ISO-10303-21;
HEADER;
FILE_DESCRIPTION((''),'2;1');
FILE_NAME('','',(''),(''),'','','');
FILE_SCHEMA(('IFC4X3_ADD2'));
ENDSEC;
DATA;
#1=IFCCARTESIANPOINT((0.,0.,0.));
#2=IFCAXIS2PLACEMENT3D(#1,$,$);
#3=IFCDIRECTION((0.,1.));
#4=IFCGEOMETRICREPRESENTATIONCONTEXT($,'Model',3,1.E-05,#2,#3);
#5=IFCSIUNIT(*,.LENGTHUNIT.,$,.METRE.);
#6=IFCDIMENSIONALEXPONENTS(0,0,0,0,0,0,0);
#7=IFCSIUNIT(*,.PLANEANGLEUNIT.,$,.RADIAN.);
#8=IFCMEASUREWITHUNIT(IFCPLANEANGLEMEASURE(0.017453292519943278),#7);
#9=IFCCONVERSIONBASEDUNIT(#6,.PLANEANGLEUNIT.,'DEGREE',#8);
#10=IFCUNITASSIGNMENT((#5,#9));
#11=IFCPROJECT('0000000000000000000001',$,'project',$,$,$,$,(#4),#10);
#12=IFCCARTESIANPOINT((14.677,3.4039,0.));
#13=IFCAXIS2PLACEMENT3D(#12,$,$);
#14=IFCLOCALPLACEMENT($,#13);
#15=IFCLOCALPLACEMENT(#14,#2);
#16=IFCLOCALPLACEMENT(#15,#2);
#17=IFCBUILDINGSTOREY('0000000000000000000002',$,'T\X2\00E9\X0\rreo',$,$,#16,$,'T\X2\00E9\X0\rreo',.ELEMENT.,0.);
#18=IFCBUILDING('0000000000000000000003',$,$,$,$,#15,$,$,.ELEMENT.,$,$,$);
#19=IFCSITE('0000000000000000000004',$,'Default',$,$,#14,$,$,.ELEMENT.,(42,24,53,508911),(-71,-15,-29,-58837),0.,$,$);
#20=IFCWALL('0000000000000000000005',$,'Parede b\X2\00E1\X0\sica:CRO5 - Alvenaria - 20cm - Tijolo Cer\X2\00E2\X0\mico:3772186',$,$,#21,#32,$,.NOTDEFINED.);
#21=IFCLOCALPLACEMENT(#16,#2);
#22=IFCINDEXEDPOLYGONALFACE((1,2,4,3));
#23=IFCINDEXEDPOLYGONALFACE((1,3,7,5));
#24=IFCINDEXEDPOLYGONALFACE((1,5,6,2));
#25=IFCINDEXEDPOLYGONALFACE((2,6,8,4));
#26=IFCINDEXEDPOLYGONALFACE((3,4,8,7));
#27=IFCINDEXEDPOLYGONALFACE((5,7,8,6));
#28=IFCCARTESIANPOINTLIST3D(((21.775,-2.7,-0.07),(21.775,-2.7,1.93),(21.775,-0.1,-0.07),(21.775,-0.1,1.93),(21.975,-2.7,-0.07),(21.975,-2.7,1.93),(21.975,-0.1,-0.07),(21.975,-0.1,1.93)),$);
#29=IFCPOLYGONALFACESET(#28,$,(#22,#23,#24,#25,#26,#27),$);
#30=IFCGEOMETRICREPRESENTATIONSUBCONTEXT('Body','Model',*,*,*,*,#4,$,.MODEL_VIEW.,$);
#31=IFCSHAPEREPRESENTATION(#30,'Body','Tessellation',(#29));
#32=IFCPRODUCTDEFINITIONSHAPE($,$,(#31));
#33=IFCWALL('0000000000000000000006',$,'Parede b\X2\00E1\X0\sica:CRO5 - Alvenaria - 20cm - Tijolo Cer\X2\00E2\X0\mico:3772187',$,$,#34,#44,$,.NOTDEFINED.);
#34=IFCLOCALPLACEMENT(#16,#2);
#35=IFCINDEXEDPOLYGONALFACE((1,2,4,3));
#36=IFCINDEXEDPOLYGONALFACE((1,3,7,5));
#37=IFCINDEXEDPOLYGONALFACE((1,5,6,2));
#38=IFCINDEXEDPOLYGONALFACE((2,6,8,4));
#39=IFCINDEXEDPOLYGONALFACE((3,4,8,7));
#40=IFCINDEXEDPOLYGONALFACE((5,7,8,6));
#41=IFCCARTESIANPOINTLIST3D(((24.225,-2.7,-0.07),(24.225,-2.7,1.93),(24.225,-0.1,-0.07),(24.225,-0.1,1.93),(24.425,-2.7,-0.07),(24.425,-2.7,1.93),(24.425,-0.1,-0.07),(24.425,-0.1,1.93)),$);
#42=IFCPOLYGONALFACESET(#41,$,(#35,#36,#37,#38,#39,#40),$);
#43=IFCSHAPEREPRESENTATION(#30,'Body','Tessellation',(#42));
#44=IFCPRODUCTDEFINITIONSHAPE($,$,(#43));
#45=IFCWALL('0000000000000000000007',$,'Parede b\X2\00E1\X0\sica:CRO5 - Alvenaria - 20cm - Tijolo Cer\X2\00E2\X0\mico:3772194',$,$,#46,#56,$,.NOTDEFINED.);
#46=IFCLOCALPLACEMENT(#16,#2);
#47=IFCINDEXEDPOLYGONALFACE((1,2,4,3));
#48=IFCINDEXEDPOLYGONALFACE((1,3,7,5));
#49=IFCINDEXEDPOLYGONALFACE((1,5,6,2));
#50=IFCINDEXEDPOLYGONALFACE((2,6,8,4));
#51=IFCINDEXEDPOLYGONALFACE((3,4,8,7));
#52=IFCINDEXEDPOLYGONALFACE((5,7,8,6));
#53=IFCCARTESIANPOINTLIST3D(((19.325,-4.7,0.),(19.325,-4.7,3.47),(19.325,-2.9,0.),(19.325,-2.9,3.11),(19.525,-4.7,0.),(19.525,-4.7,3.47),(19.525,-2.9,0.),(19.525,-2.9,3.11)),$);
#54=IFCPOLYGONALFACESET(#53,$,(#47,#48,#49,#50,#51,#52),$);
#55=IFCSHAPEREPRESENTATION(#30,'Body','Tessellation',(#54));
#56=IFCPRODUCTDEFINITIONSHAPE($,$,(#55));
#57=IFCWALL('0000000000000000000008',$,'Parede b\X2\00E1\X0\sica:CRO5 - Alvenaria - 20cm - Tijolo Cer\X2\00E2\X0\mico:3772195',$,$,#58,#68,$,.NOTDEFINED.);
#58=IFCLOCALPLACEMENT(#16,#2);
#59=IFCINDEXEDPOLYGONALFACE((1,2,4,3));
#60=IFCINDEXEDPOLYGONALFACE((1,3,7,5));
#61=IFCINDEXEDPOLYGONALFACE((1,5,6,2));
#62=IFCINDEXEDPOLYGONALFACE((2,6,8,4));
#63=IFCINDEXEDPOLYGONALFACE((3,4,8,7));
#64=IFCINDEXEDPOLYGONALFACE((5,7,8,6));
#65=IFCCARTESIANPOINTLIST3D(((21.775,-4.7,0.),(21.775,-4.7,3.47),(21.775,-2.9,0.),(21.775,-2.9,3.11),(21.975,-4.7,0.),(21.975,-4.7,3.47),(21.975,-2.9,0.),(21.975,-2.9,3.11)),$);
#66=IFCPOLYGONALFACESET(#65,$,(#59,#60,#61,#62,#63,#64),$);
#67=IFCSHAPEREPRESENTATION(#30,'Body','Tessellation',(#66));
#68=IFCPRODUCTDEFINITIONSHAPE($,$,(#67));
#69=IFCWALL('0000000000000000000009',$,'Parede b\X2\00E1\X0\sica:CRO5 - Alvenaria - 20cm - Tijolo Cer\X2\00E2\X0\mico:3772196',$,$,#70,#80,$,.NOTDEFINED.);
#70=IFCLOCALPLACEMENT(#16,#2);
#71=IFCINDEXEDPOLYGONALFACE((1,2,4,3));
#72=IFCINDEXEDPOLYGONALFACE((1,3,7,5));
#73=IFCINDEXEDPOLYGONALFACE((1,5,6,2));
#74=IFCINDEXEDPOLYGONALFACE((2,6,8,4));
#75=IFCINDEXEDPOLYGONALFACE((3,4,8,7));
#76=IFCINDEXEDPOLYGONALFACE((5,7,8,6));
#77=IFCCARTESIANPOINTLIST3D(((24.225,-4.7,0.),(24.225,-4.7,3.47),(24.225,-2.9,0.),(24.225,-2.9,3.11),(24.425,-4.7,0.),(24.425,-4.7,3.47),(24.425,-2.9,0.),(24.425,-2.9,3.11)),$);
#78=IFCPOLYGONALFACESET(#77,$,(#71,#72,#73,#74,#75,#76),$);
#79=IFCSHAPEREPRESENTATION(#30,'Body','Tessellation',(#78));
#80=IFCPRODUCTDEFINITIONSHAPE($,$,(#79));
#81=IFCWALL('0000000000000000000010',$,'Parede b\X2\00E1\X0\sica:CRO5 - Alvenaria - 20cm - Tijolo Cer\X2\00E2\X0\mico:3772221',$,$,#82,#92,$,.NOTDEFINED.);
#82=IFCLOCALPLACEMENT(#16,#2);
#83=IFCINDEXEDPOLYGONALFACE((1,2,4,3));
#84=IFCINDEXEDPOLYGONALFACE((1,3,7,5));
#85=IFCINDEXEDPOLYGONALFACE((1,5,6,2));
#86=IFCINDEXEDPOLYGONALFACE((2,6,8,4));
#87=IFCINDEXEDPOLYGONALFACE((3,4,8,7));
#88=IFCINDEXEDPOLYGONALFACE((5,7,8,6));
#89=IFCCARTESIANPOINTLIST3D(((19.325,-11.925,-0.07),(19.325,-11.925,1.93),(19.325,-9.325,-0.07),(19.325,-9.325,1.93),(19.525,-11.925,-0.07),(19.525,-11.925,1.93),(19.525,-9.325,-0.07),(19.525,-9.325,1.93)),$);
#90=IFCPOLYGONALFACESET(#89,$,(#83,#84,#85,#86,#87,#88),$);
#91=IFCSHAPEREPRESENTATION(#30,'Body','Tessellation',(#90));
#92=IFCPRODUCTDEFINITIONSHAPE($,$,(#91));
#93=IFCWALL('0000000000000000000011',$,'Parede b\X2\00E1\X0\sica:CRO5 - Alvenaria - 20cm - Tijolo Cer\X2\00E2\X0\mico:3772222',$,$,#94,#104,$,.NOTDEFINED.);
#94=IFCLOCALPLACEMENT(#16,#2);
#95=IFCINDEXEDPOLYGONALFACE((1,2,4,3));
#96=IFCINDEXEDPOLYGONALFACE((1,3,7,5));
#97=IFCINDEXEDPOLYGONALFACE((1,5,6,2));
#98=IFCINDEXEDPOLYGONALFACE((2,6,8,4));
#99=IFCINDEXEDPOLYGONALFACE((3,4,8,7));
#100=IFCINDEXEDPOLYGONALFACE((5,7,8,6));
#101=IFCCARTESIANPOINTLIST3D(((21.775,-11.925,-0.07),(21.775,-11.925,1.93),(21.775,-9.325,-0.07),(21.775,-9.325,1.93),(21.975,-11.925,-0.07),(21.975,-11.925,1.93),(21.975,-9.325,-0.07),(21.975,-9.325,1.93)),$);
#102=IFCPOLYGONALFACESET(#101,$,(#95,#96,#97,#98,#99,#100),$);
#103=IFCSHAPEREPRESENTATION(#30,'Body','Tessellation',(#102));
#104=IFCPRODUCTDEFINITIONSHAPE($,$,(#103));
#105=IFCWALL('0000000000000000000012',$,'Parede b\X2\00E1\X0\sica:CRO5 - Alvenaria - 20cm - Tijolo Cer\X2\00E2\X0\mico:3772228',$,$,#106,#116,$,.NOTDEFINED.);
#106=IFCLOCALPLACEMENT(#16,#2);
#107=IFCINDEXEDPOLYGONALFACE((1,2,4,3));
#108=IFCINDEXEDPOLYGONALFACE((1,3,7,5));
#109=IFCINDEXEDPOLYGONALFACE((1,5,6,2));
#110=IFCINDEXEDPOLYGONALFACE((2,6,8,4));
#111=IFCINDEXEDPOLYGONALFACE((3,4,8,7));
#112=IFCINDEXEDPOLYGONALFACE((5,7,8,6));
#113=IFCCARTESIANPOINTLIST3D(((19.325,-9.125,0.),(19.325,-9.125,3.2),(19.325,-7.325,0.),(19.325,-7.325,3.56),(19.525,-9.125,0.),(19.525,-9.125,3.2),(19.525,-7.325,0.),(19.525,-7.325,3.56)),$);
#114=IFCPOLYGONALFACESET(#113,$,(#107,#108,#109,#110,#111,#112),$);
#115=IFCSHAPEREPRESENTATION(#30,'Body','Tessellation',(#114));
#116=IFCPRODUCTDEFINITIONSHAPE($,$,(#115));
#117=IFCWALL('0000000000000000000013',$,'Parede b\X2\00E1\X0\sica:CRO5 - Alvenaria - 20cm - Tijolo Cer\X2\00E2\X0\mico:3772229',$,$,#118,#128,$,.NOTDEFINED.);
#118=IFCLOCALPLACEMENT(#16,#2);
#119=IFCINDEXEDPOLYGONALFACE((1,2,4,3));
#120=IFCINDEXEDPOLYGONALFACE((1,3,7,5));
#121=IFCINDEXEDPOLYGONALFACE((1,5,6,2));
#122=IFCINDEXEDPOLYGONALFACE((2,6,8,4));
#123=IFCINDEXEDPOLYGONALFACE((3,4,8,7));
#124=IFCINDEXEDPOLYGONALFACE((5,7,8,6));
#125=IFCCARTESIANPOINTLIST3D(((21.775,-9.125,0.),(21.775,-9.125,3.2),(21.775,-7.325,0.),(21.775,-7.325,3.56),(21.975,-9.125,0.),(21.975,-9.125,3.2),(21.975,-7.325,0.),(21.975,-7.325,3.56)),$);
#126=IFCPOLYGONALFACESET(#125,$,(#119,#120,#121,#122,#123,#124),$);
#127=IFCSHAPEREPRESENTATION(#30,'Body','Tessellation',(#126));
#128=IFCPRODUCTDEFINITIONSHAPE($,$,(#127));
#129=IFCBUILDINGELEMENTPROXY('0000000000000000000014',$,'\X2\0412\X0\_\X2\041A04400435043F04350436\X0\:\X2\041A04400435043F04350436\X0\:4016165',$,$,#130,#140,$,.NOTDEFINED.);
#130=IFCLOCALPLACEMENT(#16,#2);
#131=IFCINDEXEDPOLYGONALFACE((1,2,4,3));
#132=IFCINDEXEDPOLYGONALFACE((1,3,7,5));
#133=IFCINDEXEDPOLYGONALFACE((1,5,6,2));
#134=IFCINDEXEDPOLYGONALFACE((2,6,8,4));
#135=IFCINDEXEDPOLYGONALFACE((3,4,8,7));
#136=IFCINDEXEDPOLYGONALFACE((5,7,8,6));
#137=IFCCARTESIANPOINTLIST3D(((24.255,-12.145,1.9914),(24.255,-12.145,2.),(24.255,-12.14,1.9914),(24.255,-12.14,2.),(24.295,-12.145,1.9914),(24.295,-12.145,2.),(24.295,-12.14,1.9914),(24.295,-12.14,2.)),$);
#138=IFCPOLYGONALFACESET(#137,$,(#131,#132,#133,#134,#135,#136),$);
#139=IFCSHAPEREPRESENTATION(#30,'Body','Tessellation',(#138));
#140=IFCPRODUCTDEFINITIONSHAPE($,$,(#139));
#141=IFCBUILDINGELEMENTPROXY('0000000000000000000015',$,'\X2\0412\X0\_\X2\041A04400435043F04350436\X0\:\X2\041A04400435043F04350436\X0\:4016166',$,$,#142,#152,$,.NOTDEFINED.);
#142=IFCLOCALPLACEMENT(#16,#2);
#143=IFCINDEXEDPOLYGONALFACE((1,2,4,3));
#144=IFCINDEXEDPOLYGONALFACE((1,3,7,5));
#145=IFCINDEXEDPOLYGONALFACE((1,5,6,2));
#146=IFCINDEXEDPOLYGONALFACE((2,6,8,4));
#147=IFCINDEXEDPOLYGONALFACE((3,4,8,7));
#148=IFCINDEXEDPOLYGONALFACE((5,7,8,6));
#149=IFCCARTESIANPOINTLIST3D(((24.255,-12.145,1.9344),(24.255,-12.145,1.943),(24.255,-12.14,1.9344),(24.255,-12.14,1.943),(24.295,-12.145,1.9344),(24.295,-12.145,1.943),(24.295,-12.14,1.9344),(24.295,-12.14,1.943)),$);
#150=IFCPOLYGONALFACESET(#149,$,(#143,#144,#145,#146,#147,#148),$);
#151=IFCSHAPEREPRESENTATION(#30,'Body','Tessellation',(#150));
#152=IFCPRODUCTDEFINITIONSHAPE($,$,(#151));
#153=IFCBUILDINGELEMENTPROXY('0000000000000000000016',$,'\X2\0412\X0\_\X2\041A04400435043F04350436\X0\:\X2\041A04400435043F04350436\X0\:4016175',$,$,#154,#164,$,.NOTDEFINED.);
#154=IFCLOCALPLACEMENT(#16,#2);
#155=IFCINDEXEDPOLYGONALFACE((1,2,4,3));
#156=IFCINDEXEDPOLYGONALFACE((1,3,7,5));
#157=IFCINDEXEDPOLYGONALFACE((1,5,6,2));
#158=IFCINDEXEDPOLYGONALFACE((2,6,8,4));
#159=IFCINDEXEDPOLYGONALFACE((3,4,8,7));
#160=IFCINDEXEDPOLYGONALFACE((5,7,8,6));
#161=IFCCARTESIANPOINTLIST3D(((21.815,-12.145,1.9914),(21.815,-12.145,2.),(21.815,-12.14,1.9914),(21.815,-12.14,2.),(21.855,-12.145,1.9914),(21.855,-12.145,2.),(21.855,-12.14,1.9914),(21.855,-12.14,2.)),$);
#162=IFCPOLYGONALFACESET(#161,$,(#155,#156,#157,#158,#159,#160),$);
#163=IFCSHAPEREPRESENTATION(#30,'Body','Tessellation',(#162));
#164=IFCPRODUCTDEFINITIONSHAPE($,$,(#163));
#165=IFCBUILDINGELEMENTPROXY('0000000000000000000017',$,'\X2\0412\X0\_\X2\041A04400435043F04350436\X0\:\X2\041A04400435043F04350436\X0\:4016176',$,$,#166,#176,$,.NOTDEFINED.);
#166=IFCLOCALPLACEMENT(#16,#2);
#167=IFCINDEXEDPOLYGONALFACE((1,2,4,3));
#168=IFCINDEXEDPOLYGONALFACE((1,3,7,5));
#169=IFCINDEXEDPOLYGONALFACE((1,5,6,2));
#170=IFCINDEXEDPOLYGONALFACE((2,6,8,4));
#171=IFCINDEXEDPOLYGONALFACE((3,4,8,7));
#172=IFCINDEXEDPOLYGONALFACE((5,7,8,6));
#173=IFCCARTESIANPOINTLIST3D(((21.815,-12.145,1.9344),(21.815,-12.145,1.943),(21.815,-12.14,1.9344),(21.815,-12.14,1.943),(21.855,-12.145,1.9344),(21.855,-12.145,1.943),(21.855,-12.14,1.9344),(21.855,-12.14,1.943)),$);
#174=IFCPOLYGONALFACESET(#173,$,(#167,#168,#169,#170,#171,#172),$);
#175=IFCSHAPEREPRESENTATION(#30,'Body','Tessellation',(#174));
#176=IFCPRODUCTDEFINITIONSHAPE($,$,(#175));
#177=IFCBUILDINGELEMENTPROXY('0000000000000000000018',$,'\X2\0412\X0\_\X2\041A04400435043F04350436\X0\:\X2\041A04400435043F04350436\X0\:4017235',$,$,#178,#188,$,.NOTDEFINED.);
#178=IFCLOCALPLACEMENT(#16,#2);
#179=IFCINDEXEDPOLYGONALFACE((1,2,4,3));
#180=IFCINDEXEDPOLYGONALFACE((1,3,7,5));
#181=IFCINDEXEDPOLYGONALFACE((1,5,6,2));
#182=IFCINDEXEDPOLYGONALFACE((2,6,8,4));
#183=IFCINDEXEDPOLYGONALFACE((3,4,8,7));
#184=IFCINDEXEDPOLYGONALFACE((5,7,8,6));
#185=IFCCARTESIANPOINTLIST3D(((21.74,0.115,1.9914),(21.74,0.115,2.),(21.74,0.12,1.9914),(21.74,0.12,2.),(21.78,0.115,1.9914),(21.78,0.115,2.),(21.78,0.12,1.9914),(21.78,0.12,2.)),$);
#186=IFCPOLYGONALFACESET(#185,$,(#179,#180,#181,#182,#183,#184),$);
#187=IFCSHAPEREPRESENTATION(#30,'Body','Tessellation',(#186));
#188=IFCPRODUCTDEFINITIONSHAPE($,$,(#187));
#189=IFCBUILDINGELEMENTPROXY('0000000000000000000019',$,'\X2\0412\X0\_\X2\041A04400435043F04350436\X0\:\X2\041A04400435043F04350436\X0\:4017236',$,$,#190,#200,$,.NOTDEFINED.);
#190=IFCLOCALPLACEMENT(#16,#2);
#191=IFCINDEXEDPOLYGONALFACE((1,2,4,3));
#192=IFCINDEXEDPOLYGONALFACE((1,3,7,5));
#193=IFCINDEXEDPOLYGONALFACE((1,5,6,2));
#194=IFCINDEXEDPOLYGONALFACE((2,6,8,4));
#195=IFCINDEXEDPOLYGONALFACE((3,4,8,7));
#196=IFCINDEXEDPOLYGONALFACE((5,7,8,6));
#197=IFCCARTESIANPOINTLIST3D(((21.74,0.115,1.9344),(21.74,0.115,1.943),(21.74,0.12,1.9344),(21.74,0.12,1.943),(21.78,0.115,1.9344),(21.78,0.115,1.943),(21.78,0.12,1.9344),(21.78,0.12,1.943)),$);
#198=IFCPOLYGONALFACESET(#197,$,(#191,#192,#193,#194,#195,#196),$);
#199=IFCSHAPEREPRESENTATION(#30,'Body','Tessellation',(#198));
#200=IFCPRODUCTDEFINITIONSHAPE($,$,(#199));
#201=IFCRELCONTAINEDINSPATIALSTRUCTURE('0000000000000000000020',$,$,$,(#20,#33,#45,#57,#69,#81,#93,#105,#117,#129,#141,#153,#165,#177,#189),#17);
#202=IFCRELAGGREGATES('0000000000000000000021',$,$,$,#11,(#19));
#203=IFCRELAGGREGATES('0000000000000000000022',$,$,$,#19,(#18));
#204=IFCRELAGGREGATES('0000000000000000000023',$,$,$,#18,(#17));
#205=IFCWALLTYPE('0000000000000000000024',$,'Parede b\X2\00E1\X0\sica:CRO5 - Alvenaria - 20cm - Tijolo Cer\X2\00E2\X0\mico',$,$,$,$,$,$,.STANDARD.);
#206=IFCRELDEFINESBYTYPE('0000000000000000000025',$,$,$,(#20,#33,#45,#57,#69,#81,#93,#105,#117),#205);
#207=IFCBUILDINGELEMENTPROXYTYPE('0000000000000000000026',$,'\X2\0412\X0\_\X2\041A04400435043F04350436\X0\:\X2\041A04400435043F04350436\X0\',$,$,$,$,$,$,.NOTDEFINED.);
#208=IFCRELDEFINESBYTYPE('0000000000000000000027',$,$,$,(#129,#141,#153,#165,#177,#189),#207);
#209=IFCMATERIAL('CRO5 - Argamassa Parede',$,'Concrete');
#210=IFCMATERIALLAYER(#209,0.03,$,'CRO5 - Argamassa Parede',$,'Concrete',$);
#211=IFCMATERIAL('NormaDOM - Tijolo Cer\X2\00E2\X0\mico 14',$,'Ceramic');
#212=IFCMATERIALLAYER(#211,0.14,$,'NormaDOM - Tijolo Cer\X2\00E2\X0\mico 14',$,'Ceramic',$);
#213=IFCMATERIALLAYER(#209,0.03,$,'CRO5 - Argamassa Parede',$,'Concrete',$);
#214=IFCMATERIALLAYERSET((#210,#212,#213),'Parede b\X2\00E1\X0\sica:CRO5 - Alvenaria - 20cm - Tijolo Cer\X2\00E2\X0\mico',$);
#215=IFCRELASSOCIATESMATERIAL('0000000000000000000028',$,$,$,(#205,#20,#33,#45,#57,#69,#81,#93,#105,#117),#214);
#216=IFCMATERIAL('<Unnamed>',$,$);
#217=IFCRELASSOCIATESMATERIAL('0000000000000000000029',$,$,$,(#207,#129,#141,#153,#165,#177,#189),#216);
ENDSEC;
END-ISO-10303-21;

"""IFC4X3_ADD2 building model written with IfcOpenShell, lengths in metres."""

from ifc_helpers import new_model, entity, si_unit, converted_unit, direction, frame, frame_2d, origin, place, context, subcontext, project, spatial, polyline, rectangle, extrude, clip, bounded_halfspace, source, transform, mapped, material, layer, layer_set, type_object, type_shapes, element, save


model = new_model("IFC4X3_ADD2")

# Units and contexts
model_context = context("Model", 3, precision=1e-05, world=origin(), true_north=direction((0.0, 1.0)))
body_context = subcontext(model_context, "Body", "Model", "MODEL_VIEW")
ifc_project = project(units=[si_unit("LENGTHUNIT", "METRE"), converted_unit("PLANEANGLEUNIT", "DEGREE", entity("IfcPlaneAngleMeasure", 0.017453292519943278), si_unit("PLANEANGLEUNIT", "RADIAN"), dimensions=[0, 0, 0, 0, 0, 0, 0])], contexts=[model_context])

# Site, building, storey
site_placement = place(None, frame((14.677, 3.4039, 0.0)))
site = spatial("IfcSite", under=ifc_project, at=site_placement, Name="Default", CompositionType="ELEMENT", RefLatitude=(42, 24, 53, 508911), RefLongitude=(-71, -15, -29, -58837), RefElevation=0.0)
building_placement = place(site_placement, origin())
building = spatial("IfcBuilding", under=site, at=building_placement, CompositionType="ELEMENT")
storey_placement = place(building_placement, origin())
storey = spatial("IfcBuildingStorey", under=building, at=storey_placement, Name="Térreo", LongName="Térreo", CompositionType="ELEMENT", Elevation=0.0)

# Walls
ifc_material_1 = material(Name="CRO5 - Argamassa Parede", Category="Concrete")
ifc_layer_1 = layer(ifc_material_1, 0.03, Name="CRO5 - Argamassa Parede", Category="Concrete")
ifc_material_2 = material(Name="NormaDOM - Tijolo Cerâmico 14", Category="Ceramic")
ifc_layer_2 = layer(ifc_material_2, 0.14, Name="NormaDOM - Tijolo Cerâmico 14", Category="Ceramic")
ifc_layer_3 = layer(ifc_material_1, 0.03, Name="CRO5 - Argamassa Parede", Category="Concrete")
ifc_layer_set = layer_set([ifc_layer_1, ifc_layer_2, ifc_layer_3], Name="Parede básica:CRO5 - Alvenaria - 20cm - Tijolo Cerâmico")
wall_type = type_object("IfcWallType", Name="Parede básica:CRO5 - Alvenaria - 20cm - Tijolo Cerâmico", PredefinedType="STANDARD", material=ifc_layer_set)
wall_1_placement = place(storey_placement, frame((21.875, -0.1, -0.07), z_axis=(0.0, 0.0, 1.0), x_axis=(0.0, -1.0, 0.0)))
element("IfcWall", 1, at=wall_1_placement, inside=storey, type_object=wall_type, material=ifc_layer_set, Name="Parede básica:CRO5 - Alvenaria - 20cm - Tijolo Cerâmico:3772186", PredefinedType="NOTDEFINED", context=body_context, shape_type="SweptSolid", body=[
    extrude(rectangle(XDim=2.6, YDim=0.2, at=frame_2d((1.3, 0.0), x_axis=(-1.0, 0.0))), origin(), (0.0, 0.0, 1.0), 2.0),
])
wall_2_placement = place(storey_placement, frame((24.325, -0.1, -0.07), z_axis=(0.0, 0.0, 1.0), x_axis=(0.0, -1.0, 0.0)))
element("IfcWall", 2, at=wall_2_placement, inside=storey, type_object=wall_type, material=ifc_layer_set, Name="Parede básica:CRO5 - Alvenaria - 20cm - Tijolo Cerâmico:3772187", PredefinedType="NOTDEFINED", context=body_context, shape_type="SweptSolid", body=[
    extrude(rectangle(XDim=2.6, YDim=0.2, at=frame_2d((1.3, 0.0), x_axis=(-1.0, 0.0))), origin(), (0.0, 0.0, 1.0), 2.0),
])
wall_3_placement = place(storey_placement, frame((19.425, -2.9, 0.0), z_axis=(0.0, 0.0, 1.0), x_axis=(0.0, -1.0, 0.0)))
element("IfcWall", 3, at=wall_3_placement, inside=storey, type_object=wall_type, material=ifc_layer_set, Name="Parede básica:CRO5 - Alvenaria - 20cm - Tijolo Cerâmico:3772194", PredefinedType="NOTDEFINED", context=body_context, shape_type="Clipping", body=[
    clip(extrude(rectangle(XDim=1.8, YDim=0.2, at=frame_2d((0.9, 0.0), x_axis=(-1.0, 0.0))), origin(), (0.0, 0.0, 1.0), 3.47), bounded_halfspace(frame((0.0, -0.1, 3.11), z_axis=(-0.196116, 0.0, 0.980581), x_axis=(0.0, -1.0, 0.0)), False, frame((0.0, -0.1, 3.11)), polyline([(0.0, 0.0), (1.8, 0.0), (1.8, 0.2), (0.0, 0.2), (0.0, 0.0)]))),
])
for number, where, z_axis, x_axis, name in (
    (4, (21.875, -2.9, 0.0), (0.0, 0.0, 1.0), (0.0, -1.0, 0.0), "Parede básica:CRO5 - Alvenaria - 20cm - Tijolo Cerâmico:3772195"),
    (5, (24.325, -2.9, 0.0), (0.0, 0.0, 1.0), (0.0, -1.0, 0.0), "Parede básica:CRO5 - Alvenaria - 20cm - Tijolo Cerâmico:3772196"),
):
    element("IfcWall", number, at=place(storey_placement, frame(where, z_axis=z_axis, x_axis=x_axis)), inside=storey, type_object=wall_type, material=ifc_layer_set, Name=name, PredefinedType="NOTDEFINED", context=body_context, shape_type="Clipping", body=[
        clip(extrude(rectangle(XDim=1.8, YDim=0.2, at=frame_2d((0.9, 0.0), x_axis=(-1.0, 0.0))), origin(), (0.0, 0.0, 1.0), 3.47), bounded_halfspace(frame((0.0, -0.1, 3.11), z_axis=(-0.196116, 0.0, 0.980581), x_axis=(0.0, -1.0, 0.0)), False, frame((0.0, -0.1, 3.11)), polyline([(0.0, 0.0), (1.8, 0.0), (1.8, 0.2), (0.0, 0.2), (0.0, 0.0)]))),
    ])
wall_4_placement = place(storey_placement, frame((19.425, -9.325, -0.07), z_axis=(0.0, 0.0, 1.0), x_axis=(0.0, -1.0, 0.0)))
element("IfcWall", 6, at=wall_4_placement, inside=storey, type_object=wall_type, material=ifc_layer_set, Name="Parede básica:CRO5 - Alvenaria - 20cm - Tijolo Cerâmico:3772221", PredefinedType="NOTDEFINED", context=body_context, shape_type="SweptSolid", body=[
    extrude(rectangle(XDim=2.6, YDim=0.2, at=frame_2d((1.3, 0.0), x_axis=(-1.0, 0.0))), origin(), (0.0, 0.0, 1.0), 2.0),
])
wall_5_placement = place(storey_placement, frame((21.875, -9.325, -0.07), z_axis=(0.0, 0.0, 1.0), x_axis=(0.0, -1.0, 0.0)))
element("IfcWall", 7, at=wall_5_placement, inside=storey, type_object=wall_type, material=ifc_layer_set, Name="Parede básica:CRO5 - Alvenaria - 20cm - Tijolo Cerâmico:3772222", PredefinedType="NOTDEFINED", context=body_context, shape_type="SweptSolid", body=[
    extrude(rectangle(XDim=2.6, YDim=0.2, at=frame_2d((1.3, 0.0), x_axis=(-1.0, 0.0))), origin(), (0.0, 0.0, 1.0), 2.0),
])
wall_6_placement = place(storey_placement, frame((19.425, -7.325, 0.0), z_axis=(0.0, 0.0, 1.0), x_axis=(0.0, -1.0, 0.0)))
element("IfcWall", 8, at=wall_6_placement, inside=storey, type_object=wall_type, material=ifc_layer_set, Name="Parede básica:CRO5 - Alvenaria - 20cm - Tijolo Cerâmico:3772228", PredefinedType="NOTDEFINED", context=body_context, shape_type="Clipping", body=[
    clip(extrude(rectangle(XDim=1.8, YDim=0.2, at=frame_2d((0.9, 0.0), x_axis=(-1.0, 0.0))), origin(), (0.0, 0.0, 1.0), 3.56), bounded_halfspace(frame((0.0, -0.1, 3.56), z_axis=(0.196116, 0.0, 0.980581), x_axis=(0.0, 1.0, 0.0)), False, frame((0.0, -0.1, 3.56)), polyline([(0.0, 0.0), (1.8, 0.0), (1.8, 0.2), (0.0, 0.2), (0.0, 0.0)]))),
])
wall_7_placement = place(storey_placement, frame((21.875, -7.325, 0.0), z_axis=(0.0, 0.0, 1.0), x_axis=(0.0, -1.0, 0.0)))
element("IfcWall", 9, at=wall_7_placement, inside=storey, type_object=wall_type, material=ifc_layer_set, Name="Parede básica:CRO5 - Alvenaria - 20cm - Tijolo Cerâmico:3772229", PredefinedType="NOTDEFINED", context=body_context, shape_type="Clipping", body=[
    clip(extrude(rectangle(XDim=1.8, YDim=0.2, at=frame_2d((0.9, 0.0), x_axis=(-1.0, 0.0))), origin(), (0.0, 0.0, 1.0), 3.56), bounded_halfspace(frame((0.0, -0.1, 3.56), z_axis=(0.196116, 0.0, 0.980581), x_axis=(0.0, 1.0, 0.0)), False, frame((0.0, -0.1, 3.56)), polyline([(0.0, 0.0), (1.8, 0.0), (1.8, 0.2), (0.0, 0.2), (0.0, 0.0)]))),
])

# Building element proxies
ifc_material_3 = material(Name="<Unnamed>")
building_element_proxy_type_1 = type_object("IfcBuildingElementProxyType", Name="В_Крепеж:Крепеж", PredefinedType="NOTDEFINED", material=ifc_material_3)
shared_shape_1 = source(origin(), body_context, "Body", "SweptSolid", [
    extrude(rectangle(XDim=0.005, YDim=0.04, at=frame_2d((0.0, 0.0), x_axis=(1.0, 0.0))), frame((0.0, 0.0, -0.0043), z_axis=(0.0, 0.0, 1.0), x_axis=(0.0, 1.0, 0.0)), (0.0, 0.0, 1.0), 0.0086),
])
type_shapes(building_element_proxy_type_1, [shared_shape_1])
for number, where, z_axis, x_axis, name in (
    (10, (24.275, -12.1425, 1.9957), (0.0, 0.0, 1.0), (-1.0, 0.0, 0.0), "В_Крепеж:Крепеж:4016165"),
    (11, (24.275, -12.1425, 1.9387), (0.0, 0.0, 1.0), (-1.0, 0.0, 0.0), "В_Крепеж:Крепеж:4016166"),
    (12, (21.835, -12.1425, 1.9957), (0.0, 0.0, 1.0), (-1.0, 0.0, 0.0), "В_Крепеж:Крепеж:4016175"),
    (13, (21.835, -12.1425, 1.9387), (0.0, 0.0, 1.0), (-1.0, 0.0, 0.0), "В_Крепеж:Крепеж:4016176"),
):
    element("IfcBuildingElementProxy", number, at=place(storey_placement, frame(where, z_axis=z_axis, x_axis=x_axis)), inside=storey, type_object=building_element_proxy_type_1, material=ifc_material_3, Name=name, PredefinedType="NOTDEFINED", context=body_context, shape_type="MappedRepresentation", body=[
        mapped(shared_shape_1, transform((0.0, 0.0, 0.0), scale=1.0)),
    ])
for number, where, name in (
    (14, (21.76, 0.1175, 1.9957), "В_Крепеж:Крепеж:4017235"),
    (15, (21.76, 0.1175, 1.9387), "В_Крепеж:Крепеж:4017236"),
):
    element("IfcBuildingElementProxy", number, at=place(storey_placement, frame(where)), inside=storey, type_object=building_element_proxy_type_1, material=ifc_material_3, Name=name, PredefinedType="NOTDEFINED", context=body_context, shape_type="MappedRepresentation", body=[
        mapped(shared_shape_1, transform((0.0, 0.0, 0.0), scale=1.0)),
    ])

save(model, "model.ifc")
